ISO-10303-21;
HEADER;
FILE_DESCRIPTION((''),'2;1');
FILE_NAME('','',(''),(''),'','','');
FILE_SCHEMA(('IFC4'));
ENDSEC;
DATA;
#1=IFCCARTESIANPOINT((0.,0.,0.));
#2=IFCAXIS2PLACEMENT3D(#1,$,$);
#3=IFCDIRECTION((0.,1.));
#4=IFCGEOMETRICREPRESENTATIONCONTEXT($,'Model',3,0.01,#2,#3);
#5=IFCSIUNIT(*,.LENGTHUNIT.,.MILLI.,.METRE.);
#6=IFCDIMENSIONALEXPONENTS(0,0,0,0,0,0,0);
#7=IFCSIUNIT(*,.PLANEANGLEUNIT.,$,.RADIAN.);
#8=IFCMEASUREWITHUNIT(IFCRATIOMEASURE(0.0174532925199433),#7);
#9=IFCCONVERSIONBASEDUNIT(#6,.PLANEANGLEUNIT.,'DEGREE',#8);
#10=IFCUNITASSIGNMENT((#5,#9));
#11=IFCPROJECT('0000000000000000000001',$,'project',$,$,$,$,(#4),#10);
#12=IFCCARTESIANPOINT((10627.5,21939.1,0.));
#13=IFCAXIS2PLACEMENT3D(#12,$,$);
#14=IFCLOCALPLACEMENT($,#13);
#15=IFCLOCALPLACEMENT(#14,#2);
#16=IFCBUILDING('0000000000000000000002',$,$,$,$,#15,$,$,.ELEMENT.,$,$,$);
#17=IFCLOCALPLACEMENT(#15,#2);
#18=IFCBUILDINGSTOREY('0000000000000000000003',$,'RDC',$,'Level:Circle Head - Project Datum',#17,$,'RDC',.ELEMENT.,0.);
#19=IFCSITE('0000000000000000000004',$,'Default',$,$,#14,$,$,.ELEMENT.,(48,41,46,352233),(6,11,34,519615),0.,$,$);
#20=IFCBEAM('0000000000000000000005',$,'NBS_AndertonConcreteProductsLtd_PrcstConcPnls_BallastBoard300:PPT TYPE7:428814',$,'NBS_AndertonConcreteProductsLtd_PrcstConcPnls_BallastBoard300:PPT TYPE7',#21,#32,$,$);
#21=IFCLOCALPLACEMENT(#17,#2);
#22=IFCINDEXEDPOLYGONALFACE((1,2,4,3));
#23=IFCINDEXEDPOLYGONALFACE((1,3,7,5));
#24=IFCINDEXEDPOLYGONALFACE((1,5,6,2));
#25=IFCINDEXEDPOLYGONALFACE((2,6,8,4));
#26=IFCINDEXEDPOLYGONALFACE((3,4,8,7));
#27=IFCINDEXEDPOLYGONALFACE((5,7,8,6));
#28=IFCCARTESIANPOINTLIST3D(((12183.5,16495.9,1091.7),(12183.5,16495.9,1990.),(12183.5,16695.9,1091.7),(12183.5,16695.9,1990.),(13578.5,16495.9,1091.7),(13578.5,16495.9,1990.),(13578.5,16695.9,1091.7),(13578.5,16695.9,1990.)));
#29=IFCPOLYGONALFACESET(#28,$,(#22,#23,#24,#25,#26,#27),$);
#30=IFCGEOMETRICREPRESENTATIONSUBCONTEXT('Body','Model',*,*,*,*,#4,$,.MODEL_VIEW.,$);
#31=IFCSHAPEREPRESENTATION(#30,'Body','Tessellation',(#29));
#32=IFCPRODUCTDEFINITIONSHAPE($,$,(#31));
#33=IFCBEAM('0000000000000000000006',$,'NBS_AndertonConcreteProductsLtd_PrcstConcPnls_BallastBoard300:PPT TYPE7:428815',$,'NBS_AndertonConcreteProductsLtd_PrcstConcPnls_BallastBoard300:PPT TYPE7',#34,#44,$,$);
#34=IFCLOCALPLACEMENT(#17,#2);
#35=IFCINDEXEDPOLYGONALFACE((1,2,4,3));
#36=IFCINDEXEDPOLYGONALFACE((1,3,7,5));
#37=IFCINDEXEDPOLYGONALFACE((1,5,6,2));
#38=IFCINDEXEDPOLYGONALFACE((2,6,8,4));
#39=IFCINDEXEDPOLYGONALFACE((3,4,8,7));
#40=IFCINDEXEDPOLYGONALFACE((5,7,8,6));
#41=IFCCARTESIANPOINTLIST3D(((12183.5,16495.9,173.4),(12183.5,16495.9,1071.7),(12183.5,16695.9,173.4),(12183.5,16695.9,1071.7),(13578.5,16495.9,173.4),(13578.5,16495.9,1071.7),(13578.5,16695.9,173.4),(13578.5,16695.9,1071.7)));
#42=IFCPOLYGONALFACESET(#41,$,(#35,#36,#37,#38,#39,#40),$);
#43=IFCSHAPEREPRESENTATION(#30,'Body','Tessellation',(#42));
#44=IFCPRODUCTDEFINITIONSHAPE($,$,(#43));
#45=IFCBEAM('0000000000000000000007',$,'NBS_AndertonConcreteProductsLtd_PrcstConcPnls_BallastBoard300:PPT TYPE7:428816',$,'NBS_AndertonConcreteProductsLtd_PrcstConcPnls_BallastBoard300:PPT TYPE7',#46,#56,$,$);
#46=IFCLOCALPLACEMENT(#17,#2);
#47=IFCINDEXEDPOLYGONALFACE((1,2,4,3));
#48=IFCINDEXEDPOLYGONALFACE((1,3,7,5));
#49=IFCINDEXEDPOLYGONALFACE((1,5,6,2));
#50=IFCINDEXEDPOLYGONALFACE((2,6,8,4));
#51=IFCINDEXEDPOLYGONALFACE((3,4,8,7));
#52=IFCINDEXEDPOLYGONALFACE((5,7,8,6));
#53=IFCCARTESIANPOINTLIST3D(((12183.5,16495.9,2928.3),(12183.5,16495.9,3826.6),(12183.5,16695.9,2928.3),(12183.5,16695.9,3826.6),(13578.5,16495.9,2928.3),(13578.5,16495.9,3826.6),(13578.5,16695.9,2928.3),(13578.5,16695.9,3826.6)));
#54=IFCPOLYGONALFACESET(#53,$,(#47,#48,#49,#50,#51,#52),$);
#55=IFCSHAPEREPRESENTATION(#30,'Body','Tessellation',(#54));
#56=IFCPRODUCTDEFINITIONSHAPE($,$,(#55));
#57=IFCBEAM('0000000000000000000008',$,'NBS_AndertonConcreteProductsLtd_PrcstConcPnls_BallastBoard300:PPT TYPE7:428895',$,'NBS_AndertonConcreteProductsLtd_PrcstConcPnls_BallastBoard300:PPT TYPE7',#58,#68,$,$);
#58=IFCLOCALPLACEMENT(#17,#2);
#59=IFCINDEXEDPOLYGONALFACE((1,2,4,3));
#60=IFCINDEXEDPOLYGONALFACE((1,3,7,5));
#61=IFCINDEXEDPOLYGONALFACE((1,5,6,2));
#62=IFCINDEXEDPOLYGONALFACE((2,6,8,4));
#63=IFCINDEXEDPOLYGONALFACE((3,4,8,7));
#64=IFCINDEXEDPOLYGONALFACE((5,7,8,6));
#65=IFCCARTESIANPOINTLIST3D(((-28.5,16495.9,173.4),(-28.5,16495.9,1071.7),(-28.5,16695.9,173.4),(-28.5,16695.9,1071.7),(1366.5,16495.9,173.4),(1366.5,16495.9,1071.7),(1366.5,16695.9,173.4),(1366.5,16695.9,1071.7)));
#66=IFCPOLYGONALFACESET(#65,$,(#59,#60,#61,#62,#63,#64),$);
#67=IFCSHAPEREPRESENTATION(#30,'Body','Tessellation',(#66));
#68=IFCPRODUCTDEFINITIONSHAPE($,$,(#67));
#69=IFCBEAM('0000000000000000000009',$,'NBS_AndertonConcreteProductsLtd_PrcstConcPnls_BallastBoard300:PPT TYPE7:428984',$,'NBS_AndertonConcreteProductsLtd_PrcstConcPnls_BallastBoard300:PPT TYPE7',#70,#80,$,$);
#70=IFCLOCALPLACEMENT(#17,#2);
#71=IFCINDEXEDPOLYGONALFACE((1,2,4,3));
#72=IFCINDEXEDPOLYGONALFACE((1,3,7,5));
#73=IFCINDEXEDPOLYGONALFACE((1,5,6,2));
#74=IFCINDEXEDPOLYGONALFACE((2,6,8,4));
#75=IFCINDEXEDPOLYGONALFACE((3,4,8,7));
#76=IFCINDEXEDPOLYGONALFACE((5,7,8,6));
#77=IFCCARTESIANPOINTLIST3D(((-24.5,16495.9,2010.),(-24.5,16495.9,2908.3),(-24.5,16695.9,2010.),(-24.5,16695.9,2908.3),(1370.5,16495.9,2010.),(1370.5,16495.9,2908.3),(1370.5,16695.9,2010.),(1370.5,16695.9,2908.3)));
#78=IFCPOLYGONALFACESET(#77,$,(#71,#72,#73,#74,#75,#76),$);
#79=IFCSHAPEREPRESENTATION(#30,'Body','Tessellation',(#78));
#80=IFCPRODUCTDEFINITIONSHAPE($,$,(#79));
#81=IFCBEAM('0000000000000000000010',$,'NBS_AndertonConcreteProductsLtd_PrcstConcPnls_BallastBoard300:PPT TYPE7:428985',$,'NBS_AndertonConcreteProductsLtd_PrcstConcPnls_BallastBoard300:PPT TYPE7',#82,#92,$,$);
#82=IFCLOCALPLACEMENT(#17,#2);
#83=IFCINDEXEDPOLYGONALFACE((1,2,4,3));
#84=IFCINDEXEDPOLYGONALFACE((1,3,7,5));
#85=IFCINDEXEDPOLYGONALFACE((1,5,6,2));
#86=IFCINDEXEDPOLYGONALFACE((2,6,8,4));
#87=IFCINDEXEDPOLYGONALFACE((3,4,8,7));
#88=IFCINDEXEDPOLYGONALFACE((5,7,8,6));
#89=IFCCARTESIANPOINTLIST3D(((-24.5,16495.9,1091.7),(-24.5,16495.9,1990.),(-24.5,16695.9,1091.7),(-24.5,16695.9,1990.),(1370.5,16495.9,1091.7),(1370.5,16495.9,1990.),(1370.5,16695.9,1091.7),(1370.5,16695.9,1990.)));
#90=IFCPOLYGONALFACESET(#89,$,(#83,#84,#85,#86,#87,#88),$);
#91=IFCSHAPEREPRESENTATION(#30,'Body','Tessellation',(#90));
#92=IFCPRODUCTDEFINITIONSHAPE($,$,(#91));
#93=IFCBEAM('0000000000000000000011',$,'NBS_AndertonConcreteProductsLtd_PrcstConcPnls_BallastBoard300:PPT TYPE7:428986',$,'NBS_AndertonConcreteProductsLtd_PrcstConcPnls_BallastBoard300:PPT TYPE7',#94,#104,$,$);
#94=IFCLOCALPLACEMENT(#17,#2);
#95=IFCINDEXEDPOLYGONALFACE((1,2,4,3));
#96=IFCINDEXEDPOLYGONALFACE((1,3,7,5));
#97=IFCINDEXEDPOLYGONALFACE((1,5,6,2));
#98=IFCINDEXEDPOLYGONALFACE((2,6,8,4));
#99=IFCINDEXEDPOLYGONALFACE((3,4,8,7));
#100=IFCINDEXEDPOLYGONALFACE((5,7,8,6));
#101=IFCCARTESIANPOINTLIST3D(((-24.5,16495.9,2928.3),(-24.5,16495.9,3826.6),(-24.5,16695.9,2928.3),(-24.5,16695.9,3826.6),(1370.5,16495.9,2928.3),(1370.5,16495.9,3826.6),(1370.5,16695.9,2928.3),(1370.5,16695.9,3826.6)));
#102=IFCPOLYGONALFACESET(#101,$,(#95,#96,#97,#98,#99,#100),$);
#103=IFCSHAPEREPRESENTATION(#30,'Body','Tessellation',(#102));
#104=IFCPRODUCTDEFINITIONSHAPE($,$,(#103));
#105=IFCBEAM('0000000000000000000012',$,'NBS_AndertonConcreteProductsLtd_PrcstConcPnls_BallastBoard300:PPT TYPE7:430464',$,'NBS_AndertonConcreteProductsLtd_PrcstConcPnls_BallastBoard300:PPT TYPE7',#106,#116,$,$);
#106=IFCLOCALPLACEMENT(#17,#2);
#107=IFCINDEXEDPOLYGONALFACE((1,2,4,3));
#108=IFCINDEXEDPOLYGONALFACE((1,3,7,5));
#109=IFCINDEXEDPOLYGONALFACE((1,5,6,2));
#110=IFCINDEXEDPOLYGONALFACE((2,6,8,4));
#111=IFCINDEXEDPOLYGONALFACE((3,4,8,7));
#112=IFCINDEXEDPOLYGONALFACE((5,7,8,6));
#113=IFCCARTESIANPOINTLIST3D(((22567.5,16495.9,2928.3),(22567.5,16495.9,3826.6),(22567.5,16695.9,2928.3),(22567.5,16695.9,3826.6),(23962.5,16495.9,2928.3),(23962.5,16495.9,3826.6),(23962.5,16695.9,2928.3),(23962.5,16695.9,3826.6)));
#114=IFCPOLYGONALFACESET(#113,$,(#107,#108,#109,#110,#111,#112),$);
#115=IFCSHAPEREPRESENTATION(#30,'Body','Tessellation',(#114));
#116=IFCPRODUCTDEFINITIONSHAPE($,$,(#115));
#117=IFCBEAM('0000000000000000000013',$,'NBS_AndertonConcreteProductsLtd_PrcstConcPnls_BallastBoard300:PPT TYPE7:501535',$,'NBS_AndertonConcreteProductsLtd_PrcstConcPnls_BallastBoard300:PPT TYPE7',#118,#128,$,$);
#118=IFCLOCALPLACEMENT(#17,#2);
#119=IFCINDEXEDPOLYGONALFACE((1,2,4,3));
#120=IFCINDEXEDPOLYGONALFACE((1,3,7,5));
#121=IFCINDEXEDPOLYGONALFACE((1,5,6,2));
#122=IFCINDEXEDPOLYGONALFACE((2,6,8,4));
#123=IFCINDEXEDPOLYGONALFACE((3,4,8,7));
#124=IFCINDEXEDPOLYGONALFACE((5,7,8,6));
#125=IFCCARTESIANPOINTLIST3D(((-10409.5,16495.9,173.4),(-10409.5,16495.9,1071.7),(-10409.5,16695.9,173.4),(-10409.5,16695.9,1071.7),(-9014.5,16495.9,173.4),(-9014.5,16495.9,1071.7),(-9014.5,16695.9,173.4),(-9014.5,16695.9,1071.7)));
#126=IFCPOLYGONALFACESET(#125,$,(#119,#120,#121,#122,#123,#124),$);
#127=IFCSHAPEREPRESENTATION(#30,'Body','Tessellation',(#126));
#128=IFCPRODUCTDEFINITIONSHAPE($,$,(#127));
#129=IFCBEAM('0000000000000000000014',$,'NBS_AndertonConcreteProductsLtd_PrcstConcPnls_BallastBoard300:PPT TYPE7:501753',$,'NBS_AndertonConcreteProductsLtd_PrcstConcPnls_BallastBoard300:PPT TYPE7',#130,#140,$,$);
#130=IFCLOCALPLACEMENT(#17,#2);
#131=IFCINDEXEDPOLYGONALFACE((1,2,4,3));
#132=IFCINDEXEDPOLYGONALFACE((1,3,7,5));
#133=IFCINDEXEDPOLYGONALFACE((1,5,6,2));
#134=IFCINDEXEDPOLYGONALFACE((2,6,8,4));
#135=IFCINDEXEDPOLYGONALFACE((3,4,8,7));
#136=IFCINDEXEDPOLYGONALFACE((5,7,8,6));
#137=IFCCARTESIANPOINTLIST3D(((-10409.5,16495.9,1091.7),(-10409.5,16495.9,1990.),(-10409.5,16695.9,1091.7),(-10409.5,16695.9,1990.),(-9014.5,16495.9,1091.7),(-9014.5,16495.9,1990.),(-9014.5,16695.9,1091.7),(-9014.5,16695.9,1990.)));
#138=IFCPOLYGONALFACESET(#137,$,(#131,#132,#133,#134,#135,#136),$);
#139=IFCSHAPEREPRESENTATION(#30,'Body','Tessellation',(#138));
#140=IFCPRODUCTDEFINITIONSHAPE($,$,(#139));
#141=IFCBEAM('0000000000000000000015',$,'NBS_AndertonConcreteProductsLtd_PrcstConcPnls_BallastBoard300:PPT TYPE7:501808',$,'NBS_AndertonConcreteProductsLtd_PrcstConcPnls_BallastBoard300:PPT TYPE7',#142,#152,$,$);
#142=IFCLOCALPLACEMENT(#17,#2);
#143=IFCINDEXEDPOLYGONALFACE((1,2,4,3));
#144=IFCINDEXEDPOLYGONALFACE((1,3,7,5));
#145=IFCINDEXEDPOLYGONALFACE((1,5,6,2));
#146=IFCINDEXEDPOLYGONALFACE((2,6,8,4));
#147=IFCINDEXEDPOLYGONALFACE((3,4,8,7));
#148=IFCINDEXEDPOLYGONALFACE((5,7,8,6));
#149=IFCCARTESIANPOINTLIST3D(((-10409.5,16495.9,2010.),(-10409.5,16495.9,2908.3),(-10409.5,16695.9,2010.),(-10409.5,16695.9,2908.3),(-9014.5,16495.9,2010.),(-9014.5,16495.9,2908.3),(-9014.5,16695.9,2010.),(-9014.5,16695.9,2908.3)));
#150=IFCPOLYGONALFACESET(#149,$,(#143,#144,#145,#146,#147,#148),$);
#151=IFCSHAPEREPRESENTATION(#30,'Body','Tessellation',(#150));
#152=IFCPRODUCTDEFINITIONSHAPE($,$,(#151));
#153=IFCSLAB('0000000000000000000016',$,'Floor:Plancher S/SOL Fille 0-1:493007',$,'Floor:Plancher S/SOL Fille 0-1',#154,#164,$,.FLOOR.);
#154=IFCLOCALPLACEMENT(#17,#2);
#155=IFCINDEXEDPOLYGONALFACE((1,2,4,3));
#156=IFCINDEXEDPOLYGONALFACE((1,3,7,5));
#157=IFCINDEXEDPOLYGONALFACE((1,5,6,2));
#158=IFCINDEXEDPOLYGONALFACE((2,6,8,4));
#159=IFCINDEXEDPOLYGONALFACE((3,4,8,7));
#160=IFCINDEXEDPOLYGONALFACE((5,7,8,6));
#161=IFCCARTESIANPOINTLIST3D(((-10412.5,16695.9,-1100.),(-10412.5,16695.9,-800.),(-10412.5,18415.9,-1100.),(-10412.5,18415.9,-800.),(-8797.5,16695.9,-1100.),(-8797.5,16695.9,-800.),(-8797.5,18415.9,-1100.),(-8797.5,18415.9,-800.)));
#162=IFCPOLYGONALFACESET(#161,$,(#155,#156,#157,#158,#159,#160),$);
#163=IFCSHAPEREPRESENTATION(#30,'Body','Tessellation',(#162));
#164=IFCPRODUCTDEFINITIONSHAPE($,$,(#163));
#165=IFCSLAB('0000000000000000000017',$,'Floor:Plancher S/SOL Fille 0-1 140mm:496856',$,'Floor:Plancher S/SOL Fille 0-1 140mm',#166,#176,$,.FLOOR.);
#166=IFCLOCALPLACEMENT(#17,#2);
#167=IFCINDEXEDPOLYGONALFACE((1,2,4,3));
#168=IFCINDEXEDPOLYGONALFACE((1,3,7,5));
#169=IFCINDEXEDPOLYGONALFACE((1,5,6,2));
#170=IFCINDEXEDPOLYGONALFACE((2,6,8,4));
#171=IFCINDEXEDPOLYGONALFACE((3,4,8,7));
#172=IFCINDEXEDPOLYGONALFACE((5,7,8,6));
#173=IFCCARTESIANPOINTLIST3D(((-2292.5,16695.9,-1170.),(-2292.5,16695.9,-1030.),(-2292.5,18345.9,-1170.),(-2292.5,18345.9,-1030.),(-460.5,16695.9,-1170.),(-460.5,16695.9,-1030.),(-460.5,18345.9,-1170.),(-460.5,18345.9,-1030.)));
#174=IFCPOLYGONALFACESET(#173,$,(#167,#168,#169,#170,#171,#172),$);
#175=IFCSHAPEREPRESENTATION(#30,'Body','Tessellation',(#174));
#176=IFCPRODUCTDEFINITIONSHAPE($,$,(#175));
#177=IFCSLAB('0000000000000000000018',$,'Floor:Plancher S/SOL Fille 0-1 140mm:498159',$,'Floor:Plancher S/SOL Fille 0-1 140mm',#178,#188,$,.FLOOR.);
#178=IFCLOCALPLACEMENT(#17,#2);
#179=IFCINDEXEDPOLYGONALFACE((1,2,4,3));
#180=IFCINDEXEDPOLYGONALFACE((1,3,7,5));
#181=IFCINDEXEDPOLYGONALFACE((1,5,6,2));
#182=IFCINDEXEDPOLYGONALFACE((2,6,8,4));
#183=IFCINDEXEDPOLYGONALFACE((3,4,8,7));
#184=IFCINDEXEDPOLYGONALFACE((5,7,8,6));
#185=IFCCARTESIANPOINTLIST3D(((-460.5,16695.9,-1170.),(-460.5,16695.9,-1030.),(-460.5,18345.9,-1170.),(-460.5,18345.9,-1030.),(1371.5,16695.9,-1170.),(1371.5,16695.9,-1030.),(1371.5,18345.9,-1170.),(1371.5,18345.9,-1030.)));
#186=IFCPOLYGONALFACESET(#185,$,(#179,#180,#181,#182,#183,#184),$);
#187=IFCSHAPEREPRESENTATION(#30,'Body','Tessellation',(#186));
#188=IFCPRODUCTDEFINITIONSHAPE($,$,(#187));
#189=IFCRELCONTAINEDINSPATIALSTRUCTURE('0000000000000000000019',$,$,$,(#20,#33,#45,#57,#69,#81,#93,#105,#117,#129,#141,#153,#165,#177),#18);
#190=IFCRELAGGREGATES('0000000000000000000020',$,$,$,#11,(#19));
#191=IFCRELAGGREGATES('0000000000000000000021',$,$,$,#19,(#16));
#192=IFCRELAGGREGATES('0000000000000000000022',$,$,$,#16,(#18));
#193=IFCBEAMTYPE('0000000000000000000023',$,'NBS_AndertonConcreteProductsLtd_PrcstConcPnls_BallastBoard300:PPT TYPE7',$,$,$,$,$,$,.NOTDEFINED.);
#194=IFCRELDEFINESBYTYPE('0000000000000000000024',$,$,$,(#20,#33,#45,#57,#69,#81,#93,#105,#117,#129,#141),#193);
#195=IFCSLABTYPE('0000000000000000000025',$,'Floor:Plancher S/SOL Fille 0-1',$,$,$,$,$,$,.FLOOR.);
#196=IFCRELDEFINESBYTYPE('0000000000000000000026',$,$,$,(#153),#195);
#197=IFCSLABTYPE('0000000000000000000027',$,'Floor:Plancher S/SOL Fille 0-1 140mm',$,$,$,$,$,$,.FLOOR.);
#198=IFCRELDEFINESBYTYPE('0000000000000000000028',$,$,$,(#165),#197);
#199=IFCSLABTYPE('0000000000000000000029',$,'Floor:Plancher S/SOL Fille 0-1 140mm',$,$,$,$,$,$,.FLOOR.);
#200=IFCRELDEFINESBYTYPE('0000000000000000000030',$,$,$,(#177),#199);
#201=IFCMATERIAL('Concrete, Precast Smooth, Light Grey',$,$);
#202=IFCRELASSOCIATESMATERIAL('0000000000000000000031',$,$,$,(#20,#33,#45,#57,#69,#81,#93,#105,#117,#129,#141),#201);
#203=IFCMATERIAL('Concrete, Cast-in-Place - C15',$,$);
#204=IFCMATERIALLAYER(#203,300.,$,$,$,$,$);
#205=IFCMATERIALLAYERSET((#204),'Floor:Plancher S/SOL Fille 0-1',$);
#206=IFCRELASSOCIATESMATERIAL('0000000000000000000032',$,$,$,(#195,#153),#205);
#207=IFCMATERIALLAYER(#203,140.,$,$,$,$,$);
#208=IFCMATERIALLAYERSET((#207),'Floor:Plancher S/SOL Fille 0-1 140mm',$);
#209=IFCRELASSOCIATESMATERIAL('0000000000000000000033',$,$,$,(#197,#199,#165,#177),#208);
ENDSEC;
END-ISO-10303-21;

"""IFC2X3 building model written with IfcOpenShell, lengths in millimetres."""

from ifc_helpers import new_model, entity, si_unit, converted_unit, direction, frame, frame_2d, origin, origin_2d_with_axis, place, context, subcontext, project, spatial, rectangle, extrude, material, layer, layer_set, layer_usage, type_object, element, save


model = new_model("IFC2X3")

# Units and contexts
model_context = context("Model", 3, precision=0.01, world=origin(), true_north=direction((0.0, 1.0)))
body_context = subcontext(model_context, "Body", "Model", "MODEL_VIEW")
ifc_project = project(units=[si_unit("LENGTHUNIT", "METRE", prefix="MILLI"), converted_unit("PLANEANGLEUNIT", "DEGREE", entity("IfcRatioMeasure", 0.0174532925199433), si_unit("PLANEANGLEUNIT", "RADIAN"), dimensions=[0, 0, 0, 0, 0, 0, 0])], contexts=[model_context])

# Site, building, storey
site_placement = place(None, frame((10627.5, 21939.1, 0.0)))
site = spatial("IfcSite", under=ifc_project, at=site_placement, Name="Default", CompositionType="ELEMENT", RefLatitude=(48, 41, 46, 352233), RefLongitude=(6, 11, 34, 519615), RefElevation=0.0)
building_placement = place(site_placement, origin())
building = spatial("IfcBuilding", under=site, at=building_placement, CompositionType="ELEMENT")
storey_placement = place(building_placement, origin())
storey = spatial("IfcBuildingStorey", under=building, at=storey_placement, Name="RDC", ObjectType="Level:Circle Head - Project Datum", LongName="RDC", CompositionType="ELEMENT", Elevation=0.0)

# Beams
ifc_material_1 = material(Name="Concrete, Precast Smooth, Light Grey")
beam_type_1 = type_object("IfcBeamType", Name="NBS_AndertonConcreteProductsLtd_PrcstConcPnls_BallastBoard300:PPT TYPE7", PredefinedType="NOTDEFINED")
beam_1_placement = place(storey_placement, origin())
element("IfcBeam", 1, at=beam_1_placement, inside=storey, type_object=beam_type_1, material=ifc_material_1, Name="NBS_AndertonConcreteProductsLtd_PrcstConcPnls_BallastBoard300:PPT TYPE7:428814", ObjectType="NBS_AndertonConcreteProductsLtd_PrcstConcPnls_BallastBoard300:PPT TYPE7", context=body_context, shape_type="SweptSolid", body=[
    extrude(rectangle(XDim=898.3, YDim=200.0, at=frame_2d((0.0, 0.0), x_axis=(0.0, 1.0))), frame((12183.5, 16595.9, 1540.8), z_axis=(1.0, 0.0, 0.0), x_axis=(0.0, 1.0, 0.0)), (0.0, 0.0, 1.0), 1395.0),
])
beam_2_placement = place(storey_placement, origin())
element("IfcBeam", 2, at=beam_2_placement, inside=storey, type_object=beam_type_1, material=ifc_material_1, Name="NBS_AndertonConcreteProductsLtd_PrcstConcPnls_BallastBoard300:PPT TYPE7:428815", ObjectType="NBS_AndertonConcreteProductsLtd_PrcstConcPnls_BallastBoard300:PPT TYPE7", context=body_context, shape_type="SweptSolid", body=[
    extrude(rectangle(XDim=898.3, YDim=200.0, at=frame_2d((0.0, 0.0), x_axis=(0.0, 1.0))), frame((12183.5, 16595.9, 622.5), z_axis=(1.0, 0.0, 0.0), x_axis=(0.0, 1.0, 0.0)), (0.0, 0.0, 1.0), 1395.0),
])
beam_3_placement = place(storey_placement, origin())
element("IfcBeam", 3, at=beam_3_placement, inside=storey, type_object=beam_type_1, material=ifc_material_1, Name="NBS_AndertonConcreteProductsLtd_PrcstConcPnls_BallastBoard300:PPT TYPE7:428816", ObjectType="NBS_AndertonConcreteProductsLtd_PrcstConcPnls_BallastBoard300:PPT TYPE7", context=body_context, shape_type="SweptSolid", body=[
    extrude(rectangle(XDim=898.3, YDim=200.0, at=frame_2d((0.0, 0.0), x_axis=(0.0, 1.0))), frame((12183.5, 16595.9, 3377.5), z_axis=(1.0, 0.0, 0.0), x_axis=(0.0, 1.0, 0.0)), (0.0, 0.0, 1.0), 1395.0),
])
beam_4_placement = place(storey_placement, origin())
element("IfcBeam", 4, at=beam_4_placement, inside=storey, type_object=beam_type_1, material=ifc_material_1, Name="NBS_AndertonConcreteProductsLtd_PrcstConcPnls_BallastBoard300:PPT TYPE7:428895", ObjectType="NBS_AndertonConcreteProductsLtd_PrcstConcPnls_BallastBoard300:PPT TYPE7", context=body_context, shape_type="SweptSolid", body=[
    extrude(rectangle(XDim=898.3, YDim=200.0, at=frame_2d((0.0, 0.0), x_axis=(0.0, 1.0))), frame((-28.5, 16595.9, 622.5), z_axis=(1.0, 0.0, 0.0), x_axis=(0.0, 1.0, 0.0)), (0.0, 0.0, 1.0), 1395.0),
])
beam_5_placement = place(storey_placement, origin())
element("IfcBeam", 5, at=beam_5_placement, inside=storey, type_object=beam_type_1, material=ifc_material_1, Name="NBS_AndertonConcreteProductsLtd_PrcstConcPnls_BallastBoard300:PPT TYPE7:428984", ObjectType="NBS_AndertonConcreteProductsLtd_PrcstConcPnls_BallastBoard300:PPT TYPE7", context=body_context, shape_type="SweptSolid", body=[
    extrude(rectangle(XDim=898.3, YDim=200.0, at=frame_2d((0.0, 0.0), x_axis=(0.0, 1.0))), frame((-24.5, 16595.9, 2459.2), z_axis=(1.0, 0.0, 0.0), x_axis=(0.0, 1.0, 0.0)), (0.0, 0.0, 1.0), 1395.0),
])
beam_6_placement = place(storey_placement, origin())
element("IfcBeam", 6, at=beam_6_placement, inside=storey, type_object=beam_type_1, material=ifc_material_1, Name="NBS_AndertonConcreteProductsLtd_PrcstConcPnls_BallastBoard300:PPT TYPE7:428985", ObjectType="NBS_AndertonConcreteProductsLtd_PrcstConcPnls_BallastBoard300:PPT TYPE7", context=body_context, shape_type="SweptSolid", body=[
    extrude(rectangle(XDim=898.3, YDim=200.0, at=frame_2d((0.0, 0.0), x_axis=(0.0, 1.0))), frame((-24.5, 16595.9, 1540.8), z_axis=(1.0, 0.0, 0.0), x_axis=(0.0, 1.0, 0.0)), (0.0, 0.0, 1.0), 1395.0),
])
beam_7_placement = place(storey_placement, origin())
element("IfcBeam", 7, at=beam_7_placement, inside=storey, type_object=beam_type_1, material=ifc_material_1, Name="NBS_AndertonConcreteProductsLtd_PrcstConcPnls_BallastBoard300:PPT TYPE7:428986", ObjectType="NBS_AndertonConcreteProductsLtd_PrcstConcPnls_BallastBoard300:PPT TYPE7", context=body_context, shape_type="SweptSolid", body=[
    extrude(rectangle(XDim=898.3, YDim=200.0, at=frame_2d((0.0, 0.0), x_axis=(0.0, 1.0))), frame((-24.5, 16595.9, 3377.5), z_axis=(1.0, 0.0, 0.0), x_axis=(0.0, 1.0, 0.0)), (0.0, 0.0, 1.0), 1395.0),
])
beam_8_placement = place(storey_placement, origin())
element("IfcBeam", 8, at=beam_8_placement, inside=storey, type_object=beam_type_1, material=ifc_material_1, Name="NBS_AndertonConcreteProductsLtd_PrcstConcPnls_BallastBoard300:PPT TYPE7:430464", ObjectType="NBS_AndertonConcreteProductsLtd_PrcstConcPnls_BallastBoard300:PPT TYPE7", context=body_context, shape_type="SweptSolid", body=[
    extrude(rectangle(XDim=898.3, YDim=200.0, at=frame_2d((0.0, 0.0), x_axis=(0.0, 1.0))), frame((22567.5, 16595.9, 3377.5), z_axis=(1.0, 0.0, 0.0), x_axis=(0.0, 1.0, 0.0)), (0.0, 0.0, 1.0), 1395.0),
])
beam_9_placement = place(storey_placement, origin())
element("IfcBeam", 9, at=beam_9_placement, inside=storey, type_object=beam_type_1, material=ifc_material_1, Name="NBS_AndertonConcreteProductsLtd_PrcstConcPnls_BallastBoard300:PPT TYPE7:501535", ObjectType="NBS_AndertonConcreteProductsLtd_PrcstConcPnls_BallastBoard300:PPT TYPE7", context=body_context, shape_type="SweptSolid", body=[
    extrude(rectangle(XDim=898.3, YDim=200.0, at=frame_2d((0.0, 0.0), x_axis=(0.0, 1.0))), frame((-10409.5, 16595.9, 622.5), z_axis=(1.0, 0.0, 0.0), x_axis=(0.0, 1.0, 0.0)), (0.0, 0.0, 1.0), 1395.0),
])
beam_10_placement = place(storey_placement, origin())
element("IfcBeam", 10, at=beam_10_placement, inside=storey, type_object=beam_type_1, material=ifc_material_1, Name="NBS_AndertonConcreteProductsLtd_PrcstConcPnls_BallastBoard300:PPT TYPE7:501753", ObjectType="NBS_AndertonConcreteProductsLtd_PrcstConcPnls_BallastBoard300:PPT TYPE7", context=body_context, shape_type="SweptSolid", body=[
    extrude(rectangle(XDim=898.3, YDim=200.0, at=frame_2d((0.0, 0.0), x_axis=(0.0, 1.0))), frame((-10409.5, 16595.9, 1540.8), z_axis=(1.0, 0.0, 0.0), x_axis=(0.0, 1.0, 0.0)), (0.0, 0.0, 1.0), 1395.0),
])
beam_11_placement = place(storey_placement, origin())
element("IfcBeam", 11, at=beam_11_placement, inside=storey, type_object=beam_type_1, material=ifc_material_1, Name="NBS_AndertonConcreteProductsLtd_PrcstConcPnls_BallastBoard300:PPT TYPE7:501808", ObjectType="NBS_AndertonConcreteProductsLtd_PrcstConcPnls_BallastBoard300:PPT TYPE7", context=body_context, shape_type="SweptSolid", body=[
    extrude(rectangle(XDim=898.3, YDim=200.0, at=frame_2d((0.0, 0.0), x_axis=(0.0, 1.0))), frame((-10409.5, 16595.9, 2459.1), z_axis=(1.0, 0.0, 0.0), x_axis=(0.0, 1.0, 0.0)), (0.0, 0.0, 1.0), 1395.0),
])

# Slabs
ifc_material_2 = material(Name="Concrete, Cast-in-Place - C15")
ifc_layer_1 = layer(ifc_material_2, 300.0)
ifc_layer_set_1 = layer_set([ifc_layer_1], Name="Floor:Plancher S/SOL Fille 0-1")
ifc_layer_usage_1 = layer_usage(ifc_layer_set_1, "AXIS3", "POSITIVE", 0.0)
slab_type_1 = type_object("IfcSlabType", Name="Floor:Plancher S/SOL Fille 0-1", PredefinedType="FLOOR", material=ifc_layer_set_1)
slab_1_placement = place(storey_placement, origin())
element("IfcSlab", 12, at=slab_1_placement, inside=storey, type_object=slab_type_1, material=ifc_layer_usage_1, Name="Floor:Plancher S/SOL Fille 0-1:493007", ObjectType="Floor:Plancher S/SOL Fille 0-1", PredefinedType="FLOOR", context=body_context, shape_type="SweptSolid", body=[
    extrude(rectangle(XDim=1720.0, YDim=1615.0, at=frame_2d((0.0, 0.0), x_axis=(1.0, 0.0))), frame((-9605.0, 17555.9, -800.0), z_axis=(0.0, 0.0, -1.0), x_axis=(0.0, 1.0, 0.0)), (0.0, 0.0, 1.0), 300.0),
])
ifc_layer_2 = layer(ifc_material_2, 140.0)
ifc_layer_set_2 = layer_set([ifc_layer_2], Name="Floor:Plancher S/SOL Fille 0-1 140mm")
ifc_layer_usage_2 = layer_usage(ifc_layer_set_2, "AXIS3", "POSITIVE", 0.0)
slab_type_2 = type_object("IfcSlabType", Name="Floor:Plancher S/SOL Fille 0-1 140mm", PredefinedType="FLOOR", material=ifc_layer_set_2)
slab_2_placement = place(storey_placement, origin())
element("IfcSlab", 13, at=slab_2_placement, inside=storey, type_object=slab_type_2, material=ifc_layer_usage_2, Name="Floor:Plancher S/SOL Fille 0-1 140mm:496856", ObjectType="Floor:Plancher S/SOL Fille 0-1 140mm", PredefinedType="FLOOR", context=body_context, shape_type="SweptSolid", body=[
    extrude(rectangle(XDim=1650.0, YDim=1832.0, at=origin_2d_with_axis()), frame((-1376.5, 17520.9, -1030.0), z_axis=(0.0, 0.0, -1.0), x_axis=(0.0, 1.0, 0.0)), (0.0, 0.0, 1.0), 140.0),
])
ifc_layer_usage_3 = layer_usage(ifc_layer_set_2, "AXIS3", "POSITIVE", 0.0)
slab_type_3 = type_object("IfcSlabType", Name="Floor:Plancher S/SOL Fille 0-1 140mm", PredefinedType="FLOOR", material=ifc_layer_set_2)
slab_3_placement = place(storey_placement, origin())
element("IfcSlab", 14, at=slab_3_placement, inside=storey, type_object=slab_type_3, material=ifc_layer_usage_3, Name="Floor:Plancher S/SOL Fille 0-1 140mm:498159", ObjectType="Floor:Plancher S/SOL Fille 0-1 140mm", PredefinedType="FLOOR", context=body_context, shape_type="SweptSolid", body=[
    extrude(rectangle(XDim=1650.0, YDim=1832.0, at=origin_2d_with_axis()), frame((455.5, 17520.9, -1030.0), z_axis=(0.0, 0.0, -1.0), x_axis=(0.0, 1.0, 0.0)), (0.0, 0.0, 1.0), 140.0),
])

save(model, "model.ifc")
